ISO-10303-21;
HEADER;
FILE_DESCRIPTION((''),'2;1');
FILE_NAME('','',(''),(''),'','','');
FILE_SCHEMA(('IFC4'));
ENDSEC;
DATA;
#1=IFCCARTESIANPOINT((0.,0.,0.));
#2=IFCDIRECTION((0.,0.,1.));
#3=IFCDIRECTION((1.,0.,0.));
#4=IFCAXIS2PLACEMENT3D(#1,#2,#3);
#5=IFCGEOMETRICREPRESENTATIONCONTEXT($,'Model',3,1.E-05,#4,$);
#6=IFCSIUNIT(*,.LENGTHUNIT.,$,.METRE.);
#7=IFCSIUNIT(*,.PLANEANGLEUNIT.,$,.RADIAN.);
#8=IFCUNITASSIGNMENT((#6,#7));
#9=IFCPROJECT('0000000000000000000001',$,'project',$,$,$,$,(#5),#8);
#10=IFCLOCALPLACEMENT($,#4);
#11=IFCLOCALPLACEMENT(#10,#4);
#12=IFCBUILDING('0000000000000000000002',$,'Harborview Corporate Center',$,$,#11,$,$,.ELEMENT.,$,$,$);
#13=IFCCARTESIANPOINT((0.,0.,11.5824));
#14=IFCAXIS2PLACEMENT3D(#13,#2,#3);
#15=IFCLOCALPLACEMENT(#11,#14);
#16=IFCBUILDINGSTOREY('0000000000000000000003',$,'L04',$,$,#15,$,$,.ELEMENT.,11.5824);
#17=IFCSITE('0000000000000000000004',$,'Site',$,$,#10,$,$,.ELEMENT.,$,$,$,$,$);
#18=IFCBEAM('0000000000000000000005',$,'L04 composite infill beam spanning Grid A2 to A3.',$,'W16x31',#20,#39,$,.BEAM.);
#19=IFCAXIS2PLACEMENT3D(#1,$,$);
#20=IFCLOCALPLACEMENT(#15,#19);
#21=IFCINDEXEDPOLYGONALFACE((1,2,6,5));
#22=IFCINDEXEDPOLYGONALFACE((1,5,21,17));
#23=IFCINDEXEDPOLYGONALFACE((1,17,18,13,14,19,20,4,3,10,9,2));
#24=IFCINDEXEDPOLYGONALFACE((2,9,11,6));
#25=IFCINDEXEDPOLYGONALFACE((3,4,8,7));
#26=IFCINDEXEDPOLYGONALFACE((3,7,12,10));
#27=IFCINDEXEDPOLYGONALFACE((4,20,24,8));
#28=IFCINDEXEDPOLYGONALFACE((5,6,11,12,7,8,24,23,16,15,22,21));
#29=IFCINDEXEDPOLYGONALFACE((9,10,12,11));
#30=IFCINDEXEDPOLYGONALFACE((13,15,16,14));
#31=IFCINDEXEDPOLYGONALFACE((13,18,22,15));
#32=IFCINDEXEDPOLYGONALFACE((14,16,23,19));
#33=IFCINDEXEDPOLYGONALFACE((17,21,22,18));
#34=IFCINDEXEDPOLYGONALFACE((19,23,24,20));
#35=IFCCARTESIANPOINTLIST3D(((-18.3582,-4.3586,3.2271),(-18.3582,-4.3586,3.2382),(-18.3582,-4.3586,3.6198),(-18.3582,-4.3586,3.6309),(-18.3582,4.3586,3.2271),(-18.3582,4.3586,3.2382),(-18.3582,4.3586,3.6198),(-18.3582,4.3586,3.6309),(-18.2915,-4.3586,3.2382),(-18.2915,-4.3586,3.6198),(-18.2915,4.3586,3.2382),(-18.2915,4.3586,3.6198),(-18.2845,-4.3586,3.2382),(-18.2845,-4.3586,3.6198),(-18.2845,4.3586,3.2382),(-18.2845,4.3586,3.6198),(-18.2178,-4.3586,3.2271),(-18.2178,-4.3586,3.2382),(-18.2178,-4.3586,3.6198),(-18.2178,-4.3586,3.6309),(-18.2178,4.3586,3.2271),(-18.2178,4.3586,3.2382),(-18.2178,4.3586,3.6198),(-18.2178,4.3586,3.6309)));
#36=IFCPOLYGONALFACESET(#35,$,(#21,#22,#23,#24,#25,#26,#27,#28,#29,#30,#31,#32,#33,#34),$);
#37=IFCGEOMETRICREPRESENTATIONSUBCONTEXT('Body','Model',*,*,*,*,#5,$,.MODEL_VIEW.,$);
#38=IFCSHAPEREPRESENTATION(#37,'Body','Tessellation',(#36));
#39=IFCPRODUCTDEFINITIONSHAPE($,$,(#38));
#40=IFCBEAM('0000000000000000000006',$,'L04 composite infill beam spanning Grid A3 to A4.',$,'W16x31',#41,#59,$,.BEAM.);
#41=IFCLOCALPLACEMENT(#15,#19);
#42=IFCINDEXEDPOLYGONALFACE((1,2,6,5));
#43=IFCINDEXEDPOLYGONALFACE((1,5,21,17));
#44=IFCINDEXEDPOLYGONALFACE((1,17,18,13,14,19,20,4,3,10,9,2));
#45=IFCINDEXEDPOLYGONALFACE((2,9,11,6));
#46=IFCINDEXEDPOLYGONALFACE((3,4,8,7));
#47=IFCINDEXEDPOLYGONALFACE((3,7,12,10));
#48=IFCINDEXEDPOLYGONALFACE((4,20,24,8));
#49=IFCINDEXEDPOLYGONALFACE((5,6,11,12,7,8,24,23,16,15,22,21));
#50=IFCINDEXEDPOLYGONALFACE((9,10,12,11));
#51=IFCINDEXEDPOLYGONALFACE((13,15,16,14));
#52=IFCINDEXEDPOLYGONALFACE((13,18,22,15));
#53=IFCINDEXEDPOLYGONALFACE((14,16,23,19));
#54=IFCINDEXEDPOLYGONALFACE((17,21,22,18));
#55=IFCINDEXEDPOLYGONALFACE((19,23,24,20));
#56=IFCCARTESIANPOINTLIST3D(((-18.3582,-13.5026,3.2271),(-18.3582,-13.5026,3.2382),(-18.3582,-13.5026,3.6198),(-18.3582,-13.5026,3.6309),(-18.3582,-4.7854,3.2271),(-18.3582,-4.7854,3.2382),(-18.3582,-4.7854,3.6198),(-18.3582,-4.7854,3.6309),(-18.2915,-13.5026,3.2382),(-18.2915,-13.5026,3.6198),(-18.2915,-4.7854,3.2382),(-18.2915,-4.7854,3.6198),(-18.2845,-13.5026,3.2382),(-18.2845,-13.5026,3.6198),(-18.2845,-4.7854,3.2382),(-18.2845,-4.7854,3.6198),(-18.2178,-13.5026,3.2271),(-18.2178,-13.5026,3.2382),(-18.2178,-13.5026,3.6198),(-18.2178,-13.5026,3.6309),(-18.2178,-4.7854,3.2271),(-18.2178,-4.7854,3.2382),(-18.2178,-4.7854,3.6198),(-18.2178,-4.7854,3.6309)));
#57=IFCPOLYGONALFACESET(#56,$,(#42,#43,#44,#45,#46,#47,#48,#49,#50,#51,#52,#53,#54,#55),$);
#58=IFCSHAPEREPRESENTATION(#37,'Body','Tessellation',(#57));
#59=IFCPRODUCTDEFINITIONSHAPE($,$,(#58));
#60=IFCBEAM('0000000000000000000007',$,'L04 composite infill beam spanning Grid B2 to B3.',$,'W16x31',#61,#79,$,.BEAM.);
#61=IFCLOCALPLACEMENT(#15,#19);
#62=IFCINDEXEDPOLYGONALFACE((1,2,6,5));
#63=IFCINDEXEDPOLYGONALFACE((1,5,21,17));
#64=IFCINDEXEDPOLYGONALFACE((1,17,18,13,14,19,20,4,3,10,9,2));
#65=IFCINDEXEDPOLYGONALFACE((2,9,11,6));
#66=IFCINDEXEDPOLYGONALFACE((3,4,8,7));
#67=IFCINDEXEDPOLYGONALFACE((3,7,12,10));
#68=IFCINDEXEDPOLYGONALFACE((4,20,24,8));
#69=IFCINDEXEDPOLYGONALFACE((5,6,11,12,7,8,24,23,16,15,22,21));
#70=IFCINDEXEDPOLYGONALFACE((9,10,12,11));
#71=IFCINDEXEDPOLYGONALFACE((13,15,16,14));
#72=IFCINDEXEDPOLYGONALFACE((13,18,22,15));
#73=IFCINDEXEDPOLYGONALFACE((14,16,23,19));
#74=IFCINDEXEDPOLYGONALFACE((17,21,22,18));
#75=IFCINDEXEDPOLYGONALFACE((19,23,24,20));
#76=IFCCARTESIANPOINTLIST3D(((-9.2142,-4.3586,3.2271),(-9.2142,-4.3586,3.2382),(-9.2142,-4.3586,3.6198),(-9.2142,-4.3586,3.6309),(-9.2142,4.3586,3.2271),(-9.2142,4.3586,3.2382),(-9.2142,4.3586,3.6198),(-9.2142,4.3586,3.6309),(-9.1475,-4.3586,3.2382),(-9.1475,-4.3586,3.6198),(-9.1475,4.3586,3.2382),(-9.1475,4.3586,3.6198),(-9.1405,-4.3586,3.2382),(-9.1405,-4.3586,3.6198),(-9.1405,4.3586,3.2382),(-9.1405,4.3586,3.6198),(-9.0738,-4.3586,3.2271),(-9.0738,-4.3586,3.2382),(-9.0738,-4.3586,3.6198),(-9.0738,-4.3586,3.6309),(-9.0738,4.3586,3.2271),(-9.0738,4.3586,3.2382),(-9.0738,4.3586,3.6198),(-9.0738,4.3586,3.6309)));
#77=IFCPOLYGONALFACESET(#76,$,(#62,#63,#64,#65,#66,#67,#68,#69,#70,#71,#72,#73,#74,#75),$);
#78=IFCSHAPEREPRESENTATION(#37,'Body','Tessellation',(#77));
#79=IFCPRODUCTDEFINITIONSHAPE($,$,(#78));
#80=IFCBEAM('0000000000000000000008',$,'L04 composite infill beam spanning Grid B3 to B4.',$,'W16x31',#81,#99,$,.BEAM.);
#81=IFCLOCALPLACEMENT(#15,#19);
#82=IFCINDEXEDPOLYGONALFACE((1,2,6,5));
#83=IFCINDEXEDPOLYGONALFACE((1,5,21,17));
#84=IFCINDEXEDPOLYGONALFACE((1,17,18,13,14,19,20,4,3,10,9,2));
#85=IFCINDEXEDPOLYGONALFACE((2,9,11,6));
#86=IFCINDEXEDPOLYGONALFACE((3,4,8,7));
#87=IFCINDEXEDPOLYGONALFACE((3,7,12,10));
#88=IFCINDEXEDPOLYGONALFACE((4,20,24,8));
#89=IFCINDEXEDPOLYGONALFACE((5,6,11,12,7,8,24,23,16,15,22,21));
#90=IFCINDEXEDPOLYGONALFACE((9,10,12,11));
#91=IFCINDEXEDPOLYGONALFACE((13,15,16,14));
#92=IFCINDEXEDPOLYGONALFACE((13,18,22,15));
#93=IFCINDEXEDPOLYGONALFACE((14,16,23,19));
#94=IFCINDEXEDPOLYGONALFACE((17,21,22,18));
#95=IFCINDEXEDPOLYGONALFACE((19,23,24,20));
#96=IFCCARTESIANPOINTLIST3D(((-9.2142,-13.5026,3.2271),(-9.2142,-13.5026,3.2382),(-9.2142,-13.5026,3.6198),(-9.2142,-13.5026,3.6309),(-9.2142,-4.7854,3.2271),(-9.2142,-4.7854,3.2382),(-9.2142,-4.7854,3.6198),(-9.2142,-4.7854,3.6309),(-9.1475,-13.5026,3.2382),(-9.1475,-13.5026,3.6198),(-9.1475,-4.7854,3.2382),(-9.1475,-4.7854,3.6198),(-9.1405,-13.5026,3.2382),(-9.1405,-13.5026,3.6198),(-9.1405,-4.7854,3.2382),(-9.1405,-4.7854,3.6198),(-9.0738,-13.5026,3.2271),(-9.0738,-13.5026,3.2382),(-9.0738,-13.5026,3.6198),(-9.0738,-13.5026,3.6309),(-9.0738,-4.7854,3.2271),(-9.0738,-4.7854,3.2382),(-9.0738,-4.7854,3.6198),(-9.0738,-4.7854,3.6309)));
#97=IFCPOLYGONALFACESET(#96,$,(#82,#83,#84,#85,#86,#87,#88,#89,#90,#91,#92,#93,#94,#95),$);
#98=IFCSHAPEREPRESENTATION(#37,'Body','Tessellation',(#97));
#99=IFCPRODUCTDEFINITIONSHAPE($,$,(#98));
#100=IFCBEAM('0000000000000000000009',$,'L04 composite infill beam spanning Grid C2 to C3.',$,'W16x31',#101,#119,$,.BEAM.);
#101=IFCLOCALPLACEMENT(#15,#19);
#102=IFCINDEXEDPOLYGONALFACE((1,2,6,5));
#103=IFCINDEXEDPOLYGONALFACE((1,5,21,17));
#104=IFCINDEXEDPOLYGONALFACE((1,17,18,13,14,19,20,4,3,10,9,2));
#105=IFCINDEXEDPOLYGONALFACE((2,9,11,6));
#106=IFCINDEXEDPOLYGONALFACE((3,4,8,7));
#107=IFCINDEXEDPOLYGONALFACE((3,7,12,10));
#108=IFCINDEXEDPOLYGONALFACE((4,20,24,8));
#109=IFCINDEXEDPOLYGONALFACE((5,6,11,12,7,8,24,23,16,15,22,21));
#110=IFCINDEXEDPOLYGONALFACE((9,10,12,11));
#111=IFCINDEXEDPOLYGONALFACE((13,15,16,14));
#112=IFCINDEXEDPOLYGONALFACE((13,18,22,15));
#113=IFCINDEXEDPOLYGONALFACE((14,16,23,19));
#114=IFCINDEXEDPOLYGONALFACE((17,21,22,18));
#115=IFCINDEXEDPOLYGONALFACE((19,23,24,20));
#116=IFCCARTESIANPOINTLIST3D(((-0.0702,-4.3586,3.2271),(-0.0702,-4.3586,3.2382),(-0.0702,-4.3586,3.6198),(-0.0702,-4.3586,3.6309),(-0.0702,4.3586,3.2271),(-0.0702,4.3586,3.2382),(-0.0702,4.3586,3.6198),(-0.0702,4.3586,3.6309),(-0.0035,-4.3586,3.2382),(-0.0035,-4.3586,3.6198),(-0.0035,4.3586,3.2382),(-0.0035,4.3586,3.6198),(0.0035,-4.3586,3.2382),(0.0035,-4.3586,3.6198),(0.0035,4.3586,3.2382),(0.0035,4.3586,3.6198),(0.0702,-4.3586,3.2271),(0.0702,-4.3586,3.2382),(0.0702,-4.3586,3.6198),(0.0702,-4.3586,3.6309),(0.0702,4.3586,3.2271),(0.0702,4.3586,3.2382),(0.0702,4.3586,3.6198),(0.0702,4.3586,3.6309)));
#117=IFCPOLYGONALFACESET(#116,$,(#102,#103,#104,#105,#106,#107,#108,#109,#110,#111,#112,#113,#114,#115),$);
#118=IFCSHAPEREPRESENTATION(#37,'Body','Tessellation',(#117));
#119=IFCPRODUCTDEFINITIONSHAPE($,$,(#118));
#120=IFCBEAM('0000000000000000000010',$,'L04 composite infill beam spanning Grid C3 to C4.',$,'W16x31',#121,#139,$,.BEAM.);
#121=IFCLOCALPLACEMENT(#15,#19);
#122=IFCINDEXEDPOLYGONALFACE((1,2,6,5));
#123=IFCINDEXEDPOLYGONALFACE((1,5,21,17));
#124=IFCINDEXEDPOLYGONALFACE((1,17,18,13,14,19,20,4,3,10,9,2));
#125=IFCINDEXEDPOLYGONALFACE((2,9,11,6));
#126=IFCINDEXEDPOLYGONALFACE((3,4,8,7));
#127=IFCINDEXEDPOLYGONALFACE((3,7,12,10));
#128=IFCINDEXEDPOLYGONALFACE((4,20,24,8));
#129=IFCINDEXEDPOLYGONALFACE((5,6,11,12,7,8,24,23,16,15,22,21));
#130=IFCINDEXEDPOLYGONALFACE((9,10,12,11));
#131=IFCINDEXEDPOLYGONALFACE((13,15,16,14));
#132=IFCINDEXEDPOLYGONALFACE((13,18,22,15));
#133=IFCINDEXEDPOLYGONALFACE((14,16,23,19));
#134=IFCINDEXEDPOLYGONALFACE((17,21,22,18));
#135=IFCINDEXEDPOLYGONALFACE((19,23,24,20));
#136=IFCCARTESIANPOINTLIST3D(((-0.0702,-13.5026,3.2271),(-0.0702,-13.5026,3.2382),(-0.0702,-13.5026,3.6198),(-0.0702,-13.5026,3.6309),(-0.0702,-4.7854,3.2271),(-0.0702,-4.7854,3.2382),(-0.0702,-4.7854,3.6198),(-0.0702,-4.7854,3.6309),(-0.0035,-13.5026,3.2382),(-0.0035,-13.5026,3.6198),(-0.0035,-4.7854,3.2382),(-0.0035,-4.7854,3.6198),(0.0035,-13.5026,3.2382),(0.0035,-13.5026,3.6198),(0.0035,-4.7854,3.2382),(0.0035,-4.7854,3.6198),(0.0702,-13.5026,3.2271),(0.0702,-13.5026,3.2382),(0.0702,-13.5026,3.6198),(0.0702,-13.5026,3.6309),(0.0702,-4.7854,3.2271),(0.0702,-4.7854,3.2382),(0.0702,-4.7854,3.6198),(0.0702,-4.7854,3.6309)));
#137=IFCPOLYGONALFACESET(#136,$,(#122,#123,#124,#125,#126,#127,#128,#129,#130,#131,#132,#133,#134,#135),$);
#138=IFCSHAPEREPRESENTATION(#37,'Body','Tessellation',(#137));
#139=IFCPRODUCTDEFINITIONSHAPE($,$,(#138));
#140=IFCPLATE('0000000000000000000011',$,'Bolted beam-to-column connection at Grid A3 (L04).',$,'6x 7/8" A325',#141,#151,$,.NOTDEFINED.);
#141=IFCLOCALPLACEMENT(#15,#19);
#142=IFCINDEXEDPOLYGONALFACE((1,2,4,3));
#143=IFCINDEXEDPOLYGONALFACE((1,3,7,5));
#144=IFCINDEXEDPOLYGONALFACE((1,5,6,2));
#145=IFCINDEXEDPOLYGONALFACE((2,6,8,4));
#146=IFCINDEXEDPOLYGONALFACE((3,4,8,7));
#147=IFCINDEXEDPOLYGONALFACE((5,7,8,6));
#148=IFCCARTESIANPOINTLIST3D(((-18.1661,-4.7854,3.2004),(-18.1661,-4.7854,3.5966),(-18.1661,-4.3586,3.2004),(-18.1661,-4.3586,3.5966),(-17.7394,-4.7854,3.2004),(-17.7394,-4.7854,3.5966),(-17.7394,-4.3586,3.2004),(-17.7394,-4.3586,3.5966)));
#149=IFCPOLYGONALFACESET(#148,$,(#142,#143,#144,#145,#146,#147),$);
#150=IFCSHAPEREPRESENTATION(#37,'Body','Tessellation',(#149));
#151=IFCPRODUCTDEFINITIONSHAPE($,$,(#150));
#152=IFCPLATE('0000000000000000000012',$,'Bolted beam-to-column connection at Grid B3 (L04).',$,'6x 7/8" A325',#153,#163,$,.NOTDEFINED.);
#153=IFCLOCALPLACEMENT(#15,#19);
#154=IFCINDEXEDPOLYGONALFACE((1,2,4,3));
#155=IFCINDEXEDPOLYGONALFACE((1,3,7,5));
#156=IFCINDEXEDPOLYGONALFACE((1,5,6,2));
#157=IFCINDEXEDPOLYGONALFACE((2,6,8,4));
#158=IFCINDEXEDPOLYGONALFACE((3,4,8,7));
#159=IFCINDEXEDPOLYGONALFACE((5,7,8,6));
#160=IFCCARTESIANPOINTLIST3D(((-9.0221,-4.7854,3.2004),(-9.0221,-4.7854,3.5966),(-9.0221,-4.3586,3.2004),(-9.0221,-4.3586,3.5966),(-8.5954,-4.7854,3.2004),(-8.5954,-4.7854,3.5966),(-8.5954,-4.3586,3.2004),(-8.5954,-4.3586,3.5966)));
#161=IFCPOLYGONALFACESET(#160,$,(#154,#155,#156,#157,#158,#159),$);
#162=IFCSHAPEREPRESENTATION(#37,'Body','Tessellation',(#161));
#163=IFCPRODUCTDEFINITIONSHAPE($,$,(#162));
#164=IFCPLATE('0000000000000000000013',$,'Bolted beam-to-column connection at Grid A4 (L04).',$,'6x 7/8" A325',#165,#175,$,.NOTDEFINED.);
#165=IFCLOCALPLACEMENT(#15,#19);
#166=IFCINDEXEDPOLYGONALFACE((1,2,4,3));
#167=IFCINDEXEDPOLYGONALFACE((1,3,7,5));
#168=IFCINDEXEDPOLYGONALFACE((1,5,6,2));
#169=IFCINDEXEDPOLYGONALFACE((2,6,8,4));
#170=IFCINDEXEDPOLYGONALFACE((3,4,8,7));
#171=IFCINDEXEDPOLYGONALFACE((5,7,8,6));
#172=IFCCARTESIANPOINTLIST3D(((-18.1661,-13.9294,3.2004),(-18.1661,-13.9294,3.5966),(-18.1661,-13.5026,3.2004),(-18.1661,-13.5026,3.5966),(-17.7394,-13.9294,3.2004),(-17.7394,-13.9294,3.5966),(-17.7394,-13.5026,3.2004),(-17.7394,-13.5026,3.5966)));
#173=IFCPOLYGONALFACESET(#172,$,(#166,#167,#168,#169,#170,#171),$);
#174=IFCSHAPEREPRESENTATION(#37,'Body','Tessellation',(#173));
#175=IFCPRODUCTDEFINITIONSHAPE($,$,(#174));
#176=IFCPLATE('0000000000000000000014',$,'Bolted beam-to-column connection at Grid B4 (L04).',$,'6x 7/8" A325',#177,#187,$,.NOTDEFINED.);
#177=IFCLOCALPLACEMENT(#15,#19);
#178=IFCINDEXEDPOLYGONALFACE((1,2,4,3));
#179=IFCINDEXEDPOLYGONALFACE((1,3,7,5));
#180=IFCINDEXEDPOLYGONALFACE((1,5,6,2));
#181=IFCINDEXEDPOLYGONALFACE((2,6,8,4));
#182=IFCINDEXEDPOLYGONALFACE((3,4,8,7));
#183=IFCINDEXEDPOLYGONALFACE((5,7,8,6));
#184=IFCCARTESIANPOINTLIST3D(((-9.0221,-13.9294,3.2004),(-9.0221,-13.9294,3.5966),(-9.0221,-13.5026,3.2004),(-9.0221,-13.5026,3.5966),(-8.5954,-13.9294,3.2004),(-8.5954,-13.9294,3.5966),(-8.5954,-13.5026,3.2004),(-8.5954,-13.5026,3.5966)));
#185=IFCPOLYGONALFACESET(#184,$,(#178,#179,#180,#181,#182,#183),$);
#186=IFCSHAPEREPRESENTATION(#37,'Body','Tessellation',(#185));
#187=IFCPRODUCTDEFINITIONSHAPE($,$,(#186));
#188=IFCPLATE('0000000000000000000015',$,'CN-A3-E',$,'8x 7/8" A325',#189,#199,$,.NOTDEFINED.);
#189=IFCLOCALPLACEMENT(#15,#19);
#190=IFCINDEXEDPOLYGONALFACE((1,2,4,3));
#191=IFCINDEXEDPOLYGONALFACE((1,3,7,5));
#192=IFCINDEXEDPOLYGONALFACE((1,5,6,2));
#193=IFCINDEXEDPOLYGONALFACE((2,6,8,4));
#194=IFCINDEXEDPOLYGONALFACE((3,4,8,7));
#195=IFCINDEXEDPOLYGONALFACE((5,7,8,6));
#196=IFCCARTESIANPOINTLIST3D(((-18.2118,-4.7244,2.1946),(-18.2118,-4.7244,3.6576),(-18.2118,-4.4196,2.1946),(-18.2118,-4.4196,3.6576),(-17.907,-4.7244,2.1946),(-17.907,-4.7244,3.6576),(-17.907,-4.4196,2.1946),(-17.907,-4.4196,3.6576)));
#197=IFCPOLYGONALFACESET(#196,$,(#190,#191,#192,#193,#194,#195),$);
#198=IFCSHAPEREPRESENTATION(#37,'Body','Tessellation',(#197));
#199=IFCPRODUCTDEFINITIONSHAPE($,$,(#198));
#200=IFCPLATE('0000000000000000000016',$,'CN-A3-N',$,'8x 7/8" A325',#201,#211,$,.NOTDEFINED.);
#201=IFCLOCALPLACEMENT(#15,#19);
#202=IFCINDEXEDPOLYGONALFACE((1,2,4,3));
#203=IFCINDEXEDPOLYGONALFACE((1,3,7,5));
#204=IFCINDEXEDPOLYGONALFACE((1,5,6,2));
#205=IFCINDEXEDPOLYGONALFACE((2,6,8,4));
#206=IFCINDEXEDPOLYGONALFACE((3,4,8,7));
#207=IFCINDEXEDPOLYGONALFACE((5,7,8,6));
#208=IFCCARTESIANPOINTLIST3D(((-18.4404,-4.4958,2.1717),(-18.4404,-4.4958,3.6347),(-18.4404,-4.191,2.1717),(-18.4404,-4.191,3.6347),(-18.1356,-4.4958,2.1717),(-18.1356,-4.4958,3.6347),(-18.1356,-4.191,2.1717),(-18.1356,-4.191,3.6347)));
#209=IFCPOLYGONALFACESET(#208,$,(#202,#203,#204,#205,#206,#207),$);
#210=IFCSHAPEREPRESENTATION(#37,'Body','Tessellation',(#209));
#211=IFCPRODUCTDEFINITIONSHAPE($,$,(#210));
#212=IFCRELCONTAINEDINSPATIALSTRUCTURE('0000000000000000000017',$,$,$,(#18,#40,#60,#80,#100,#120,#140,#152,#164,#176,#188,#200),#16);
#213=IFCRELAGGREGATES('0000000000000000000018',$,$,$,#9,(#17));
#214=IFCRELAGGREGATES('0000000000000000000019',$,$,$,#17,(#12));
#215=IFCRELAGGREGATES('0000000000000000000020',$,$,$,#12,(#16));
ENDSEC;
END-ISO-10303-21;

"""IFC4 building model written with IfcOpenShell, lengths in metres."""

from ifc_helpers import new_model, si_unit, frame, origin_with_axes, place, context, subcontext, project, spatial, rectangle, i_section, extrude, element, save


model = new_model("IFC4")

# Units and contexts
model_context = context("Model", 3, precision=1e-05, world=origin_with_axes())
body_context = subcontext(model_context, "Body", "Model", "MODEL_VIEW")
ifc_project = project(units=[si_unit("LENGTHUNIT", "METRE"), si_unit("PLANEANGLEUNIT", "RADIAN")], contexts=[model_context])

# Site, building, storey
site_placement = place(None, origin_with_axes())
site = spatial("IfcSite", under=ifc_project, at=site_placement, Name="Site", CompositionType="ELEMENT")
building_placement = place(site_placement, origin_with_axes())
building = spatial("IfcBuilding", under=site, at=building_placement, Name="Harborview Corporate Center", CompositionType="ELEMENT")
storey_placement = place(building_placement, frame((0.0, 0.0, 11.5824), z_axis=(0.0, 0.0, 1.0), x_axis=(1.0, 0.0, 0.0)))
storey = spatial("IfcBuildingStorey", under=building, at=storey_placement, Name="L04", CompositionType="ELEMENT", Elevation=11.5824)

# Beams
beam_1_placement = place(storey_placement, frame((-18.288, -4.3586, 3.429), z_axis=(0.0, 1.0, 0.0), x_axis=(-1.0, 0.0, 0.0)))
element("IfcBeam", 1, at=beam_1_placement, inside=storey, Name="L04 composite infill beam spanning Grid A2 to A3.", ObjectType="W16x31", PredefinedType="BEAM", context=body_context, shape_type="SweptSolid", body=[
    extrude(i_section(OverallWidth=0.1405, OverallDepth=0.4039, WebThickness=0.007, FlangeThickness=0.0112), origin_with_axes(), (0.0, 0.0, 1.0), 8.7173),
])
beam_2_placement = place(storey_placement, frame((-18.288, -13.5026, 3.429), z_axis=(0.0, 1.0, 0.0), x_axis=(-1.0, 0.0, 0.0)))
element("IfcBeam", 2, at=beam_2_placement, inside=storey, Name="L04 composite infill beam spanning Grid A3 to A4.", ObjectType="W16x31", PredefinedType="BEAM", context=body_context, shape_type="SweptSolid", body=[
    extrude(i_section(OverallWidth=0.1405, OverallDepth=0.4039, WebThickness=0.007, FlangeThickness=0.0112), origin_with_axes(), (0.0, 0.0, 1.0), 8.7173),
])
beam_3_placement = place(storey_placement, frame((-9.144, -4.3586, 3.429), z_axis=(0.0, 1.0, 0.0), x_axis=(-1.0, 0.0, 0.0)))
element("IfcBeam", 3, at=beam_3_placement, inside=storey, Name="L04 composite infill beam spanning Grid B2 to B3.", ObjectType="W16x31", PredefinedType="BEAM", context=body_context, shape_type="SweptSolid", body=[
    extrude(i_section(OverallWidth=0.1405, OverallDepth=0.4039, WebThickness=0.007, FlangeThickness=0.0112), origin_with_axes(), (0.0, 0.0, 1.0), 8.7173),
])
beam_4_placement = place(storey_placement, frame((-9.144, -13.5026, 3.429), z_axis=(0.0, 1.0, 0.0), x_axis=(-1.0, 0.0, 0.0)))
element("IfcBeam", 4, at=beam_4_placement, inside=storey, Name="L04 composite infill beam spanning Grid B3 to B4.", ObjectType="W16x31", PredefinedType="BEAM", context=body_context, shape_type="SweptSolid", body=[
    extrude(i_section(OverallWidth=0.1405, OverallDepth=0.4039, WebThickness=0.007, FlangeThickness=0.0112), origin_with_axes(), (0.0, 0.0, 1.0), 8.7173),
])
beam_5_placement = place(storey_placement, frame((0.0, -4.3586, 3.429), z_axis=(0.0, 1.0, 0.0), x_axis=(-1.0, 0.0, 0.0)))
element("IfcBeam", 5, at=beam_5_placement, inside=storey, Name="L04 composite infill beam spanning Grid C2 to C3.", ObjectType="W16x31", PredefinedType="BEAM", context=body_context, shape_type="SweptSolid", body=[
    extrude(i_section(OverallWidth=0.1405, OverallDepth=0.4039, WebThickness=0.007, FlangeThickness=0.0112), origin_with_axes(), (0.0, 0.0, 1.0), 8.7173),
])
beam_6_placement = place(storey_placement, frame((0.0, -13.5026, 3.429), z_axis=(0.0, 1.0, 0.0), x_axis=(-1.0, 0.0, 0.0)))
element("IfcBeam", 6, at=beam_6_placement, inside=storey, Name="L04 composite infill beam spanning Grid C3 to C4.", ObjectType="W16x31", PredefinedType="BEAM", context=body_context, shape_type="SweptSolid", body=[
    extrude(i_section(OverallWidth=0.1405, OverallDepth=0.4039, WebThickness=0.007, FlangeThickness=0.0112), origin_with_axes(), (0.0, 0.0, 1.0), 8.7173),
])

# Plates
plate_1_placement = place(storey_placement, frame((-17.9527, -4.572, 3.2004), z_axis=(0.0, 0.0, 1.0), x_axis=(1.0, 0.0, 0.0)))
element("IfcPlate", 7, at=plate_1_placement, inside=storey, Name="Bolted beam-to-column connection at Grid A3 (L04).", ObjectType="6x 7/8\" A325", PredefinedType="NOTDEFINED", context=body_context, shape_type="SweptSolid", body=[
    extrude(rectangle(XDim=0.4267, YDim=0.4267), origin_with_axes(), (0.0, 0.0, 1.0), 0.3962),
])
plate_2_placement = place(storey_placement, frame((-8.8087, -4.572, 3.2004), z_axis=(0.0, 0.0, 1.0), x_axis=(1.0, 0.0, 0.0)))
element("IfcPlate", 8, at=plate_2_placement, inside=storey, Name="Bolted beam-to-column connection at Grid B3 (L04).", ObjectType="6x 7/8\" A325", PredefinedType="NOTDEFINED", context=body_context, shape_type="SweptSolid", body=[
    extrude(rectangle(XDim=0.4267, YDim=0.4267), origin_with_axes(), (0.0, 0.0, 1.0), 0.3962),
])
plate_3_placement = place(storey_placement, frame((-17.9527, -13.716, 3.2004), z_axis=(0.0, 0.0, 1.0), x_axis=(1.0, 0.0, 0.0)))
element("IfcPlate", 9, at=plate_3_placement, inside=storey, Name="Bolted beam-to-column connection at Grid A4 (L04).", ObjectType="6x 7/8\" A325", PredefinedType="NOTDEFINED", context=body_context, shape_type="SweptSolid", body=[
    extrude(rectangle(XDim=0.4267, YDim=0.4267), origin_with_axes(), (0.0, 0.0, 1.0), 0.3962),
])
plate_4_placement = place(storey_placement, frame((-8.8087, -13.716, 3.2004), z_axis=(0.0, 0.0, 1.0), x_axis=(1.0, 0.0, 0.0)))
element("IfcPlate", 10, at=plate_4_placement, inside=storey, Name="Bolted beam-to-column connection at Grid B4 (L04).", ObjectType="6x 7/8\" A325", PredefinedType="NOTDEFINED", context=body_context, shape_type="SweptSolid", body=[
    extrude(rectangle(XDim=0.4267, YDim=0.4267), origin_with_axes(), (0.0, 0.0, 1.0), 0.3962),
])
for number, where, z_axis, x_axis, name in (
    (11, (-18.0594, -4.572, 2.1946), (0.0, 0.0, 1.0), (1.0, 0.0, 0.0), "CN-A3-E"),
    (12, (-18.288, -4.3434, 2.1717), (0.0, 0.0, 1.0), (1.0, 0.0, 0.0), "CN-A3-N"),
):
    element("IfcPlate", number, at=place(storey_placement, frame(where, z_axis=z_axis, x_axis=x_axis)), inside=storey, Name=name, ObjectType="8x 7/8\" A325", PredefinedType="NOTDEFINED", context=body_context, shape_type="SweptSolid", body=[
        extrude(rectangle(XDim=0.3048, YDim=0.3048), origin_with_axes(), (0.0, 0.0, 1.0), 1.463),
    ])

save(model, "model.ifc")
